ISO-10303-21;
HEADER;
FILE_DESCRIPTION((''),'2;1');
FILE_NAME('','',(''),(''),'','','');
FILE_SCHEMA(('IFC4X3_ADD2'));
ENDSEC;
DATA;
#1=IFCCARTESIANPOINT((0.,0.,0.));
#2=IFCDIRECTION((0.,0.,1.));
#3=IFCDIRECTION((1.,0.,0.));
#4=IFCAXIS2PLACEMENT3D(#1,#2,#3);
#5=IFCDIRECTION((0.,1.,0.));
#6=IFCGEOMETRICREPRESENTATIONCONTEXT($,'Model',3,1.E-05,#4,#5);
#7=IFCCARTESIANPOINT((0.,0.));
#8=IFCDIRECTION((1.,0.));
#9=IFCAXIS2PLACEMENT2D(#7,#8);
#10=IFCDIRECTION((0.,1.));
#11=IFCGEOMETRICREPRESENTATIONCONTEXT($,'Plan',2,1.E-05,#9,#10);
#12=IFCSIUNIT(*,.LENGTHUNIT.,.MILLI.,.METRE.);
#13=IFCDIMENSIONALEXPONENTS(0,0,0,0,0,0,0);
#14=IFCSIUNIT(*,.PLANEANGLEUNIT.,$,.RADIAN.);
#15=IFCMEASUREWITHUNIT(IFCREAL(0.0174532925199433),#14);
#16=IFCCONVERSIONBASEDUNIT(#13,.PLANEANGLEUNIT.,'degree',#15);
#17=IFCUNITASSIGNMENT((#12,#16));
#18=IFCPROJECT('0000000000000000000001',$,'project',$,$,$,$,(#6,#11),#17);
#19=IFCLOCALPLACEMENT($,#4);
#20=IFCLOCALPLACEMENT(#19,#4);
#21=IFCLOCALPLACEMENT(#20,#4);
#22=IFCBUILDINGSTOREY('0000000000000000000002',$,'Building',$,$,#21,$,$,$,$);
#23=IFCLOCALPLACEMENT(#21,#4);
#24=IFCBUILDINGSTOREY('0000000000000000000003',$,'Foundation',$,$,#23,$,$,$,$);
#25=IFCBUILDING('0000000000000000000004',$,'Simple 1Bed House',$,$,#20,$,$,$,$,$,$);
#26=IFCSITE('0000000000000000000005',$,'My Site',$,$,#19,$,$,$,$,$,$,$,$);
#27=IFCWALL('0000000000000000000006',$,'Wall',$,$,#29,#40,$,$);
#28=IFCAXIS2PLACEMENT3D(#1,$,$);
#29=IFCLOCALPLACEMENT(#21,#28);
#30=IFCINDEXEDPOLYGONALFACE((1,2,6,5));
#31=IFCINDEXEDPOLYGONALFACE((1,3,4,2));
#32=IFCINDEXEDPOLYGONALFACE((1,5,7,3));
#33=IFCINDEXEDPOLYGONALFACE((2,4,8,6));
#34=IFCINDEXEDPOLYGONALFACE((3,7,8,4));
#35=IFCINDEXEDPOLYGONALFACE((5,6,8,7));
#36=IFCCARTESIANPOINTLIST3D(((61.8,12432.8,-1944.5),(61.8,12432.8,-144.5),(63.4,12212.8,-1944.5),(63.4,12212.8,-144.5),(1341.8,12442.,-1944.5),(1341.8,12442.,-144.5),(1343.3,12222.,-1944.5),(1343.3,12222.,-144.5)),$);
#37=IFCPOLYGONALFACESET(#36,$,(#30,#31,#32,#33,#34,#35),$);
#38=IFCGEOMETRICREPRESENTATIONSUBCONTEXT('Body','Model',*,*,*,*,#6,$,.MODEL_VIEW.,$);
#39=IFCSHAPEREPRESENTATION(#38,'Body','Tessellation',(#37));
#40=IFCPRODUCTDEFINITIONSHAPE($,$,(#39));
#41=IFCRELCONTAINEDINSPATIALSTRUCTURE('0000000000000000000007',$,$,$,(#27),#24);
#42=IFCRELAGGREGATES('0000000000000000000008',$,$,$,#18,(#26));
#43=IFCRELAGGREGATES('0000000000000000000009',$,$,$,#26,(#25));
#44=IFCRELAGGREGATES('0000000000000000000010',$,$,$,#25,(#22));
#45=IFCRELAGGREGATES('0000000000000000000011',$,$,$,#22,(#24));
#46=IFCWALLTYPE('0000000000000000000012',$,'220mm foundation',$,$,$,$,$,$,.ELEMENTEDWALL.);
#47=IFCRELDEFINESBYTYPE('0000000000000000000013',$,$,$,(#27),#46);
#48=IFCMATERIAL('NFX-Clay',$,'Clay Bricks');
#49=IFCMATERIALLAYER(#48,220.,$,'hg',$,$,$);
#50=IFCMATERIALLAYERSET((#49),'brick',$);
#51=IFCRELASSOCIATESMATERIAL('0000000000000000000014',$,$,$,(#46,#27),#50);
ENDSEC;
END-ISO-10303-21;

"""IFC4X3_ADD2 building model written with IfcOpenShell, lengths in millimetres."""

from ifc_helpers import new_model, entity, si_unit, converted_unit, direction, frame, origin_with_axes, origin_2d_with_axis, place, context, subcontext, project, spatial, indexed_curve, outline, extrude, material, layer, layer_set, layer_usage, type_object, element, save


model = new_model("IFC4X3_ADD2")

# Units and contexts
model_context = context("Model", 3, precision=1e-05, world=origin_with_axes(), true_north=direction((0.0, 1.0, 0.0)))
plan_context = context("Plan", 2, precision=1e-05, world=origin_2d_with_axis(), true_north=direction((0.0, 1.0)))
body_context = subcontext(model_context, "Body", "Model", "MODEL_VIEW")
ifc_project = project(units=[si_unit("LENGTHUNIT", "METRE", prefix="MILLI"), converted_unit("PLANEANGLEUNIT", "degree", entity("IfcReal", 0.0174532925199433), si_unit("PLANEANGLEUNIT", "RADIAN"), dimensions=[0, 0, 0, 0, 0, 0, 0])], contexts=[model_context, plan_context])

# Site, building, storeys
site_placement = place(None, origin_with_axes())
site = spatial("IfcSite", under=ifc_project, at=site_placement, Name="My Site")
building_placement = place(site_placement, origin_with_axes())
building = spatial("IfcBuilding", under=site, at=building_placement, Name="Simple 1Bed House")
storey_1_placement = place(building_placement, origin_with_axes())
storey_1 = spatial("IfcBuildingStorey", under=building, at=storey_1_placement, Name="Building")
storey_2_placement = place(storey_1_placement, origin_with_axes())
storey_2 = spatial("IfcBuildingStorey", under=storey_1, at=storey_2_placement, Name="Foundation")

# Wall
ifc_material_1 = material(Name="NFX-Clay", Category="Clay Bricks")
ifc_layer_1 = layer(ifc_material_1, 220.0, Name="hg")
ifc_layer_set_1 = layer_set([ifc_layer_1], Name="brick")
wall_type = type_object("IfcWallType", Name="220mm foundation", PredefinedType="ELEMENTEDWALL", material=ifc_layer_set_1)
ifc_layer_usage_1 = layer_usage(ifc_layer_set_1, "AXIS2", "POSITIVE", 0.0)
wall_1_placement = place(storey_2_placement, frame((63.4, 12212.8, -1944.5), z_axis=(0.0, 0.0, 1.0), x_axis=(0.999974, 0.007176, 0.0)))
element("IfcWall", 1, at=wall_1_placement, inside=storey_2, type_object=wall_type, material=ifc_layer_usage_1, Name="Wall", context=body_context, shape_type="SweptSolid", body=[
    extrude(outline(indexed_curve([(0.0, 0.0), (0.0, 220.0), (1280.0, 220.0), (1280.0, 0.0), (0.0, 0.0)], self_intersect=False)), origin_with_axes(), (0.0, 0.0, 1.0), 1800.0),
])

save(model, "model.ifc")
